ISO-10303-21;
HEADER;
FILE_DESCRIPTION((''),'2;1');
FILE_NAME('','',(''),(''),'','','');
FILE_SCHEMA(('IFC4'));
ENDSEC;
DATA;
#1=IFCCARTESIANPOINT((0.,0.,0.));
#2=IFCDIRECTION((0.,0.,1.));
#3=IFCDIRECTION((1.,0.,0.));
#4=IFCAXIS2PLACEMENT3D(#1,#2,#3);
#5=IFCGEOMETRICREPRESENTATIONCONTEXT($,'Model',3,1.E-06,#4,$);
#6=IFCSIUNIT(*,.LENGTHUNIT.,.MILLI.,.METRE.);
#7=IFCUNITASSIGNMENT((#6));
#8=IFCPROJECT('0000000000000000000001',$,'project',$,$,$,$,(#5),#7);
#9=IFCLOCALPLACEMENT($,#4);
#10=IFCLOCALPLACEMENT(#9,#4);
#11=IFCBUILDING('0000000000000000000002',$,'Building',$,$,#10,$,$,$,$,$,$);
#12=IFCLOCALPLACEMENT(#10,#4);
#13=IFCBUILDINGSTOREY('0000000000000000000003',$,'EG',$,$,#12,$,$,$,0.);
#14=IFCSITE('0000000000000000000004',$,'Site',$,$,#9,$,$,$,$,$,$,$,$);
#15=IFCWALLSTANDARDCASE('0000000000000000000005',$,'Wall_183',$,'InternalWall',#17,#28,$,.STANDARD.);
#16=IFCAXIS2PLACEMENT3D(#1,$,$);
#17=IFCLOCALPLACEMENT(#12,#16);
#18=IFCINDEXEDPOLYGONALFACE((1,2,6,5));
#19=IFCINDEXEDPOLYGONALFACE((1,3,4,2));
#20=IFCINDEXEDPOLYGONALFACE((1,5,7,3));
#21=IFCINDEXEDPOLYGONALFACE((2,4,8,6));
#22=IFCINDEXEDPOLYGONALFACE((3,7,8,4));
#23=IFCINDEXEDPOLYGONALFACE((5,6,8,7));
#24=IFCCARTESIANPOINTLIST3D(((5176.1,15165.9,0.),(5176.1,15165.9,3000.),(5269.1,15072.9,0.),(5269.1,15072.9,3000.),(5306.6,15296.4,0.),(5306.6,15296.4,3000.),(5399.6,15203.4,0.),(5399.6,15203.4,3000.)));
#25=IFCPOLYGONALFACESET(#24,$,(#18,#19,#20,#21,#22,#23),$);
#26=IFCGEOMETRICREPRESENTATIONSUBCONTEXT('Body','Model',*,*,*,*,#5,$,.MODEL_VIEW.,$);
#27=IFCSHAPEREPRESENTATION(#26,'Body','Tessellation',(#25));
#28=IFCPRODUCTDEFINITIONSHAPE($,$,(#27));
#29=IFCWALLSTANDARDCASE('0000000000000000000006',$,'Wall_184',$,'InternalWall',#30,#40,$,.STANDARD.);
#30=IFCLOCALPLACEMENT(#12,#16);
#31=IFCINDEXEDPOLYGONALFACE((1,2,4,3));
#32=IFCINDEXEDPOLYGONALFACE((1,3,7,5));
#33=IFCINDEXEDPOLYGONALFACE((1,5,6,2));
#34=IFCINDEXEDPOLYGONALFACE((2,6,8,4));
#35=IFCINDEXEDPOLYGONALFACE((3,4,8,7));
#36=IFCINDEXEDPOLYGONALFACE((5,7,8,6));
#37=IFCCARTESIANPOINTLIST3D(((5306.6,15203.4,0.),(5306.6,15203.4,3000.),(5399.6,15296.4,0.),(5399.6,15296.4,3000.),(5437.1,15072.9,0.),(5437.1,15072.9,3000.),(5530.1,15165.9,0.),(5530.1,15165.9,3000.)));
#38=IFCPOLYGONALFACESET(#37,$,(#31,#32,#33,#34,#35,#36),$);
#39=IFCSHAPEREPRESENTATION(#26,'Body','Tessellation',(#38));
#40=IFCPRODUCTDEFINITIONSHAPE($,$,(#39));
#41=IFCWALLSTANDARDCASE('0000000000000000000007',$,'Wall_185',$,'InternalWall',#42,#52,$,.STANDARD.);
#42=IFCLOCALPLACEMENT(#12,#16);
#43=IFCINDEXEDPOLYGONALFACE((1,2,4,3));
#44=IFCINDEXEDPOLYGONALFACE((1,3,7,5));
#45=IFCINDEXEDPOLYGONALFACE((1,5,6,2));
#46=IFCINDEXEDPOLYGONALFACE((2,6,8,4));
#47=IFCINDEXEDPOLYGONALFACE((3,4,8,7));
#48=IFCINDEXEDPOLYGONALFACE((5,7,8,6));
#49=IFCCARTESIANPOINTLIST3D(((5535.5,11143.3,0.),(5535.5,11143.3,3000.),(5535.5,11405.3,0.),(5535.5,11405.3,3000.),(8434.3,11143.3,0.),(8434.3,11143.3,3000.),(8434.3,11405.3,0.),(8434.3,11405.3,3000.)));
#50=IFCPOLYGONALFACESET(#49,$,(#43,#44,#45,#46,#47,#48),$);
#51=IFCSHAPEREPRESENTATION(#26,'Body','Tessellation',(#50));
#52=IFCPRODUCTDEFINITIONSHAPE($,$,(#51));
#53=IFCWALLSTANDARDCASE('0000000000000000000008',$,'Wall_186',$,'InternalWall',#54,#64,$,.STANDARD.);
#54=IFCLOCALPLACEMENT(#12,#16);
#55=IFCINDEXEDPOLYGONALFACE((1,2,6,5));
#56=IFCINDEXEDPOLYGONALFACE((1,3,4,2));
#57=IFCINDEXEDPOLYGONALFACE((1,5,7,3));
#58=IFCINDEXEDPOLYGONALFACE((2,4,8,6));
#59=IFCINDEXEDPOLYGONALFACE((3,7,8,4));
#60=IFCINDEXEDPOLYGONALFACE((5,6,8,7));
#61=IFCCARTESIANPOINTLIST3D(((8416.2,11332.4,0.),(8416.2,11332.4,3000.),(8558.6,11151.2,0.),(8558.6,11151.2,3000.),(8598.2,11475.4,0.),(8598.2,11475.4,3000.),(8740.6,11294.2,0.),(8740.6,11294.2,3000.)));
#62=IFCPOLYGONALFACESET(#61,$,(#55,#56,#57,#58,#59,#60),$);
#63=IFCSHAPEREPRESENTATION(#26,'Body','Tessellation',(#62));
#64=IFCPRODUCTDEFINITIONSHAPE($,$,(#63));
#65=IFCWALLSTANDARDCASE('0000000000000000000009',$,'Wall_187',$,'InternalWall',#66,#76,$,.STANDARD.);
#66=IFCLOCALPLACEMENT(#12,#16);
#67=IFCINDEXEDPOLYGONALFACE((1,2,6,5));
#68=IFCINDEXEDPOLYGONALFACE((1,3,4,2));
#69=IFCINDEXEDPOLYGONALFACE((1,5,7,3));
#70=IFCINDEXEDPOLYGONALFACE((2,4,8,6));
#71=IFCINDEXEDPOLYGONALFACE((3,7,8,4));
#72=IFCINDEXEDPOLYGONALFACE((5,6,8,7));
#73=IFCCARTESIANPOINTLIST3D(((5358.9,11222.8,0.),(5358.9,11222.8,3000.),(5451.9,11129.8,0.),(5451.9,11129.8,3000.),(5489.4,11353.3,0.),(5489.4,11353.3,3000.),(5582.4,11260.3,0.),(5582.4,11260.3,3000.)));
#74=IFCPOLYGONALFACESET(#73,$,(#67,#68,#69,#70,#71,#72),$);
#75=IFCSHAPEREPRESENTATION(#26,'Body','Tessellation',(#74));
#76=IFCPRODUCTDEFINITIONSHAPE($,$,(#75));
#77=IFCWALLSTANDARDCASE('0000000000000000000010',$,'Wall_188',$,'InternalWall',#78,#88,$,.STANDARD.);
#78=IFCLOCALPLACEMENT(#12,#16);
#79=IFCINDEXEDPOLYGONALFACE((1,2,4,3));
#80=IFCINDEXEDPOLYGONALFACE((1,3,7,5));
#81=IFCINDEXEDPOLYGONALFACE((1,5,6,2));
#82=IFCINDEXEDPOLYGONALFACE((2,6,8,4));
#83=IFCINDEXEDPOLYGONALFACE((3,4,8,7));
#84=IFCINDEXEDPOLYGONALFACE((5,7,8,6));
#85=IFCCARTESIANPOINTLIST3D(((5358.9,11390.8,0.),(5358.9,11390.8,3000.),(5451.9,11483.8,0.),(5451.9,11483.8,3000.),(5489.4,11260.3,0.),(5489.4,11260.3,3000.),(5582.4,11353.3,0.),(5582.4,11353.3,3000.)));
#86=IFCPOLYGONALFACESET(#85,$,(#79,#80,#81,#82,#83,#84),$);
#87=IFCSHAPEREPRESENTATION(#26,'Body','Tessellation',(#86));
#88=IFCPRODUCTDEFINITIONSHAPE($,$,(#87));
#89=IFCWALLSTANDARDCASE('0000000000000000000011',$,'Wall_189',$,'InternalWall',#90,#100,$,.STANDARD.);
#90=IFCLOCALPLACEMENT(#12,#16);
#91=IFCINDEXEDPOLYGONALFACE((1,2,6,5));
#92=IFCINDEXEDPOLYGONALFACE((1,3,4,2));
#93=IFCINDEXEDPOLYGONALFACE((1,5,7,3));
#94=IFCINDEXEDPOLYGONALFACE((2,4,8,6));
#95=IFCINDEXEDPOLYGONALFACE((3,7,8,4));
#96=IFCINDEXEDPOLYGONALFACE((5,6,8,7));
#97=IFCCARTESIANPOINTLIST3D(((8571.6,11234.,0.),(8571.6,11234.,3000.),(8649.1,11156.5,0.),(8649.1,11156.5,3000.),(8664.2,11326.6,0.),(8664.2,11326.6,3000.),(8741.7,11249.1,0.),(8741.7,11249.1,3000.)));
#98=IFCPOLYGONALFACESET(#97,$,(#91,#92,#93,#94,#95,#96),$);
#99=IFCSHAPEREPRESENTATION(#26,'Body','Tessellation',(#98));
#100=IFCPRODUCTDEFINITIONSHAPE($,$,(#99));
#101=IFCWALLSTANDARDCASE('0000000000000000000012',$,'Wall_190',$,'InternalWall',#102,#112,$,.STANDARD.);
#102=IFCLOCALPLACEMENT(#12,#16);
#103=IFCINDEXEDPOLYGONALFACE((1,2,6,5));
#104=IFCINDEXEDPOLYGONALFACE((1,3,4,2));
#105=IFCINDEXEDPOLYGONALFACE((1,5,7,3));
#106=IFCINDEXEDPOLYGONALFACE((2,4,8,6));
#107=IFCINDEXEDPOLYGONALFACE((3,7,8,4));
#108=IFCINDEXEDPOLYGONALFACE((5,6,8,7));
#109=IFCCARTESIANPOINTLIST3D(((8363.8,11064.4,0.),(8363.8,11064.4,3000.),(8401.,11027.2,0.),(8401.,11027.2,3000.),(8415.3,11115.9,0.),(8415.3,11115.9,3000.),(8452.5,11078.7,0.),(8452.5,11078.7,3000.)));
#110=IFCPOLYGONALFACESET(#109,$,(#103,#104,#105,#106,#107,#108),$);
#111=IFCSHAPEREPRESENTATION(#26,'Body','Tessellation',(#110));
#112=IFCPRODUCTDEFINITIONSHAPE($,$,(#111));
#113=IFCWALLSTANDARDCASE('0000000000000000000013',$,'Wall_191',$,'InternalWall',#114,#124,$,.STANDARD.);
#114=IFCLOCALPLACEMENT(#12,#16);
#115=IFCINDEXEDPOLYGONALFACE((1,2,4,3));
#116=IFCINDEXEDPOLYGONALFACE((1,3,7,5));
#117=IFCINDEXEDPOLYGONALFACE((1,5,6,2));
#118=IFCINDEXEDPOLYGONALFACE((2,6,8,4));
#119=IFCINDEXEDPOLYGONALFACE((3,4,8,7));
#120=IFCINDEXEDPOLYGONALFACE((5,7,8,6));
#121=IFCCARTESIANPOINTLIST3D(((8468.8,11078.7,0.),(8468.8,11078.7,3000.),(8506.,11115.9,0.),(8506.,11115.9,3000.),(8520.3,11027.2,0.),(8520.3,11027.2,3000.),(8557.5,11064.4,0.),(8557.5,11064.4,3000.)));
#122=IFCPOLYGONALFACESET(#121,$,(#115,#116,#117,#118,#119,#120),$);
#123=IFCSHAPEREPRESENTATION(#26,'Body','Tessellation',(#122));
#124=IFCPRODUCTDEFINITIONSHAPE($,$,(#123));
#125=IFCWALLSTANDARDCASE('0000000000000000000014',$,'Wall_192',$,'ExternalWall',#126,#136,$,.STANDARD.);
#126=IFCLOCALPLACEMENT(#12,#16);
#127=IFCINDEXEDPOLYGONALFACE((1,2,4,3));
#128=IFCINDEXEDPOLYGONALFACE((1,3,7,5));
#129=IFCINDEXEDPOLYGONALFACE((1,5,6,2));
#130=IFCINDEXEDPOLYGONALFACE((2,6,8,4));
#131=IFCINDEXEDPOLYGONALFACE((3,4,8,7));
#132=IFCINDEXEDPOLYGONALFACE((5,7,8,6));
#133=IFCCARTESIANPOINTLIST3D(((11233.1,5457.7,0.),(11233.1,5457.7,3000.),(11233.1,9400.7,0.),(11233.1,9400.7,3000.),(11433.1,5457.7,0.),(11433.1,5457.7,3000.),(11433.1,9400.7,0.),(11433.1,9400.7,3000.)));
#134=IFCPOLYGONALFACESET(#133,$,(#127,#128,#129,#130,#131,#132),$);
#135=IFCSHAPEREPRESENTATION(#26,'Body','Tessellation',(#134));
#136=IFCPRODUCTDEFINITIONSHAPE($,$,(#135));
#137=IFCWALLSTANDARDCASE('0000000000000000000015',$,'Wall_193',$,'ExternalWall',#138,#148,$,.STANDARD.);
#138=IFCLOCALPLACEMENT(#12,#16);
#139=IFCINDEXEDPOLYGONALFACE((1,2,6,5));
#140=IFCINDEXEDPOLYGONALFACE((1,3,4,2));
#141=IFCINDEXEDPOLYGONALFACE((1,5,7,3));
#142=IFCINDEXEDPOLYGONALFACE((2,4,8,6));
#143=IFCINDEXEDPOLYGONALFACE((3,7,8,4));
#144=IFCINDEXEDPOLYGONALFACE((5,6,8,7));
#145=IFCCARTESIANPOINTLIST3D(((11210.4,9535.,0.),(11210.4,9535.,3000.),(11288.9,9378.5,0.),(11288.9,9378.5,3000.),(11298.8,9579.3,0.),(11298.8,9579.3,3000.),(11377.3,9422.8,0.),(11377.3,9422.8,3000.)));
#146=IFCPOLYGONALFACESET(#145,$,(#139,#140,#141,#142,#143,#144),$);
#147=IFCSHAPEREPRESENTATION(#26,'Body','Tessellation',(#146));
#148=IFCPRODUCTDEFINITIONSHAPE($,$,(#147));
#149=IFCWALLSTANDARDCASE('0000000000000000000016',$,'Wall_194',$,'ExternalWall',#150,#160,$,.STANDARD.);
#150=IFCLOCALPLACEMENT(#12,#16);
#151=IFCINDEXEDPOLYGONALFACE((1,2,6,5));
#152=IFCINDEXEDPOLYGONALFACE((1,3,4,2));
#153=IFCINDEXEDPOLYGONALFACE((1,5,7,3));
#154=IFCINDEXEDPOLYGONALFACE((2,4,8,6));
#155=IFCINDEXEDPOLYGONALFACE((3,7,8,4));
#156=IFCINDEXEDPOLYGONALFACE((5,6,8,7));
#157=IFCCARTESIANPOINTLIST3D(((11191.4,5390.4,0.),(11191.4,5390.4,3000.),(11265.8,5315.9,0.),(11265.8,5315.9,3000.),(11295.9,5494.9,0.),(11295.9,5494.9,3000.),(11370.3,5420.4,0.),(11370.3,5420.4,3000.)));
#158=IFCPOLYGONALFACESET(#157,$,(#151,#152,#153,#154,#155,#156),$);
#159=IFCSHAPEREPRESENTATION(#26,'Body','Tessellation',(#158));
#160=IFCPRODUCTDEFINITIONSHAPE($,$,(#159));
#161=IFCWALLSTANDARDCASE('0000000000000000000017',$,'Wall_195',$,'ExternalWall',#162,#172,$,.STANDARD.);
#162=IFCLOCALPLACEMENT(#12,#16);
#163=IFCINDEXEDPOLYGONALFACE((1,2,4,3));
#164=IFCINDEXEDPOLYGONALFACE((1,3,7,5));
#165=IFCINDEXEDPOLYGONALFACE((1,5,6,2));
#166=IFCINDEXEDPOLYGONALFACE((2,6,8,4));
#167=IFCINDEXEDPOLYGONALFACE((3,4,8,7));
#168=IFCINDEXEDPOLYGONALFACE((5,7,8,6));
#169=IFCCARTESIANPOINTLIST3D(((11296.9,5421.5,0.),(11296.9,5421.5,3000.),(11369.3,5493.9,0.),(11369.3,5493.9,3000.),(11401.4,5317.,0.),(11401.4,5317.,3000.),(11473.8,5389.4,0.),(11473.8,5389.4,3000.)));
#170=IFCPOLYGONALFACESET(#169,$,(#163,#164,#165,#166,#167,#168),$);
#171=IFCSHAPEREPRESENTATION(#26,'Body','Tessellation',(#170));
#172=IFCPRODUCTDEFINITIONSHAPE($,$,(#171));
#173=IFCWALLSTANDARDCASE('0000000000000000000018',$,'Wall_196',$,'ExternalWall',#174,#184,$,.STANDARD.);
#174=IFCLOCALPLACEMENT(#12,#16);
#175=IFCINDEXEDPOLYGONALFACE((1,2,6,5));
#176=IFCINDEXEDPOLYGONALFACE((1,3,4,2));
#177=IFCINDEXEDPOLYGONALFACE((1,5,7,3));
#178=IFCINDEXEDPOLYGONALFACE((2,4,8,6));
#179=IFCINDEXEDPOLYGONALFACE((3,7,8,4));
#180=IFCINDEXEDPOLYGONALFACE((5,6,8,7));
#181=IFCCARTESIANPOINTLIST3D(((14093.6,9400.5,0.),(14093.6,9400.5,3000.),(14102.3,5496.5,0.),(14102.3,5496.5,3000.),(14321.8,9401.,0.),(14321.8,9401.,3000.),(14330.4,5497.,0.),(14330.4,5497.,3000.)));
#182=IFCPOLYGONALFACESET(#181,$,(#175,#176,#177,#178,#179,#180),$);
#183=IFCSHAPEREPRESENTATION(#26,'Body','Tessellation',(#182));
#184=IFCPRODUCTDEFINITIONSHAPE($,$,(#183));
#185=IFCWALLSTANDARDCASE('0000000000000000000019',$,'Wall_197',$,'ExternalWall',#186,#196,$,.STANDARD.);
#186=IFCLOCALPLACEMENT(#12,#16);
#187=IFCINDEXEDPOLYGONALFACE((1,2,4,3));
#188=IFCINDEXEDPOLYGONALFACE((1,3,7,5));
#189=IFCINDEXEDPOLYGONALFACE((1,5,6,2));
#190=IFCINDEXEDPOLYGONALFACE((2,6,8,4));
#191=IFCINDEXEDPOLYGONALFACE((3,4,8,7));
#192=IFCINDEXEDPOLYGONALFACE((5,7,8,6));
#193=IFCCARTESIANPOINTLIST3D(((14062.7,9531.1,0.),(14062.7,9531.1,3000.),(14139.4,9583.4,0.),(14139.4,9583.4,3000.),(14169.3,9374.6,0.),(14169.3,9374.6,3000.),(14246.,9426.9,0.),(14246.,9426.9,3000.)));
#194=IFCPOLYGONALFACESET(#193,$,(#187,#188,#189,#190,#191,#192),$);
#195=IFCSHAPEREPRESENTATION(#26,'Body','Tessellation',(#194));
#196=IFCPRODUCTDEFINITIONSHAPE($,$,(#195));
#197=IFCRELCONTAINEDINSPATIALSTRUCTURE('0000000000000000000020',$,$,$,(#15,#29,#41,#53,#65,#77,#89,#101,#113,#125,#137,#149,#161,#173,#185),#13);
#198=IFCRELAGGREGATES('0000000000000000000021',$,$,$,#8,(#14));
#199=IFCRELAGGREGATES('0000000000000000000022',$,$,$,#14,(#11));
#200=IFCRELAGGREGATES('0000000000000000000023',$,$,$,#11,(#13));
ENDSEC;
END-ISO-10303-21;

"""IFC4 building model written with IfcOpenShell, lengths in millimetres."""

from ifc_helpers import new_model, si_unit, frame, origin_with_axes, place, context, subcontext, project, spatial, rectangle, extrude, element, save


model = new_model("IFC4")

# Units and contexts
model_context = context("Model", 3, precision=1e-06, world=origin_with_axes())
body_context = subcontext(model_context, "Body", "Model", "MODEL_VIEW")
ifc_project = project(units=[si_unit("LENGTHUNIT", "METRE", prefix="MILLI")], contexts=[model_context])

# Site, building, storey
site_placement = place(None, origin_with_axes())
site = spatial("IfcSite", under=ifc_project, at=site_placement, Name="Site")
building_placement = place(site_placement, origin_with_axes())
building = spatial("IfcBuilding", under=site, at=building_placement, Name="Building")
storey_placement = place(building_placement, origin_with_axes())
storey = spatial("IfcBuildingStorey", under=building, at=storey_placement, Name="EG", Elevation=0.0)

# Walls
wall_1_placement = place(storey_placement, origin_with_axes())
element("IfcWallStandardCase", 1, at=wall_1_placement, inside=storey, Name="Wall_183", ObjectType="InternalWall", PredefinedType="STANDARD", context=body_context, shape_type="SweptSolid", body=[
    extrude(rectangle(XDim=184.6, YDim=131.5), frame((5287.9, 15184.7, 0.0), z_axis=(0.0, 0.0, 1.0), x_axis=(-0.707107, -0.707107, 0.0)), (0.0, 0.0, 1.0), 3000.0),
])
wall_2_placement = place(storey_placement, origin_with_axes())
element("IfcWallStandardCase", 2, at=wall_2_placement, inside=storey, Name="Wall_184", ObjectType="InternalWall", PredefinedType="STANDARD", context=body_context, shape_type="SweptSolid", body=[
    extrude(rectangle(XDim=184.6, YDim=131.5), frame((5418.4, 15184.7, 0.0), z_axis=(0.0, 0.0, 1.0), x_axis=(0.707107, -0.707107, 0.0)), (0.0, 0.0, 1.0), 3000.0),
])
wall_3_placement = place(storey_placement, origin_with_axes())
element("IfcWallStandardCase", 3, at=wall_3_placement, inside=storey, Name="Wall_185", ObjectType="InternalWall", PredefinedType="STANDARD", context=body_context, shape_type="SweptSolid", body=[
    extrude(rectangle(XDim=2898.7, YDim=262.0), frame((6984.9, 11274.3, 0.0), z_axis=(0.0, 0.0, 1.0), x_axis=(-1.0, 0.0, 0.0)), (0.0, 0.0, 1.0), 3000.0),
])
wall_4_placement = place(storey_placement, origin_with_axes())
element("IfcWallStandardCase", 4, at=wall_4_placement, inside=storey, Name="Wall_186", ObjectType="InternalWall", PredefinedType="STANDARD", context=body_context, shape_type="SweptSolid", body=[
    extrude(rectangle(XDim=231.5, YDim=230.5), frame((8578.4, 11313.3, 0.0), z_axis=(0.0, 0.0, 1.0), x_axis=(0.786318, 0.617822, 0.0)), (0.0, 0.0, 1.0), 3000.0),
])
wall_5_placement = place(storey_placement, origin_with_axes())
element("IfcWallStandardCase", 5, at=wall_5_placement, inside=storey, Name="Wall_187", ObjectType="InternalWall", PredefinedType="STANDARD", context=body_context, shape_type="SweptSolid", body=[
    extrude(rectangle(XDim=184.6, YDim=131.5), frame((5470.6, 11241.6, 0.0), z_axis=(0.0, 0.0, 1.0), x_axis=(-0.707107, -0.707107, 0.0)), (0.0, 0.0, 1.0), 3000.0),
])
wall_6_placement = place(storey_placement, origin_with_axes())
element("IfcWallStandardCase", 6, at=wall_6_placement, inside=storey, Name="Wall_188", ObjectType="InternalWall", PredefinedType="STANDARD", context=body_context, shape_type="SweptSolid", body=[
    extrude(rectangle(XDim=184.6, YDim=131.5), frame((5470.6, 11372.1, 0.0), z_axis=(0.0, 0.0, 1.0), x_axis=(-0.707107, 0.707107, 0.0)), (0.0, 0.0, 1.0), 3000.0),
])
wall_7_placement = place(storey_placement, origin_with_axes())
element("IfcWallStandardCase", 7, at=wall_7_placement, inside=storey, Name="Wall_189", ObjectType="InternalWall", PredefinedType="STANDARD", context=body_context, shape_type="SweptSolid", body=[
    extrude(rectangle(XDim=109.6, YDim=131.0), frame((8656.6, 11241.6, 0.0), z_axis=(0.0, 0.0, 1.0), x_axis=(0.707107, -0.707107, 0.0)), (0.0, 0.0, 1.0), 3000.0),
])
wall_8_placement = place(storey_placement, origin_with_axes())
element("IfcWallStandardCase", 8, at=wall_8_placement, inside=storey, Name="Wall_190", ObjectType="InternalWall", PredefinedType="STANDARD", context=body_context, shape_type="SweptSolid", body=[
    extrude(rectangle(XDim=72.8, YDim=52.5), frame((8408.1, 11071.6, 0.0), z_axis=(0.0, 0.0, 1.0), x_axis=(-0.707107, -0.707107, 0.0)), (0.0, 0.0, 1.0), 3000.0),
])
wall_9_placement = place(storey_placement, origin_with_axes())
element("IfcWallStandardCase", 9, at=wall_9_placement, inside=storey, Name="Wall_191", ObjectType="InternalWall", PredefinedType="STANDARD", context=body_context, shape_type="SweptSolid", body=[
    extrude(rectangle(XDim=72.8, YDim=52.5), frame((8513.1, 11071.6, 0.0), z_axis=(0.0, 0.0, 1.0), x_axis=(0.707107, -0.707107, 0.0)), (0.0, 0.0, 1.0), 3000.0),
])
wall_10_placement = place(storey_placement, origin_with_axes())
element("IfcWallStandardCase", 10, at=wall_10_placement, inside=storey, Name="Wall_192", ObjectType="ExternalWall", PredefinedType="STANDARD", context=body_context, shape_type="SweptSolid", body=[
    extrude(rectangle(XDim=3943.0, YDim=200.0), frame((11333.1, 7429.2, 0.0), z_axis=(0.0, 0.0, 1.0), x_axis=(0.0, -1.0, 0.0)), (0.0, 0.0, 1.0), 3000.0),
])
wall_11_placement = place(storey_placement, origin_with_axes())
element("IfcWallStandardCase", 11, at=wall_11_placement, inside=storey, Name="Wall_193", ObjectType="ExternalWall", PredefinedType="STANDARD", context=body_context, shape_type="SweptSolid", body=[
    extrude(rectangle(XDim=175.1, YDim=98.8), frame((11293.8, 9478.9, 0.0), z_axis=(0.0, 0.0, 1.0), x_axis=(-0.448356, 0.893855, 0.0)), (0.0, 0.0, 1.0), 3000.0),
])
wall_12_placement = place(storey_placement, origin_with_axes())
element("IfcWallStandardCase", 12, at=wall_12_placement, inside=storey, Name="Wall_194", ObjectType="ExternalWall", PredefinedType="STANDARD", context=body_context, shape_type="SweptSolid", body=[
    extrude(rectangle(XDim=147.8, YDim=105.3), frame((11280.8, 5405.4, 0.0), z_axis=(0.0, 0.0, 1.0), x_axis=(-0.707107, -0.707107, 0.0)), (0.0, 0.0, 1.0), 3000.0),
])
wall_13_placement = place(storey_placement, origin_with_axes())
element("IfcWallStandardCase", 13, at=wall_13_placement, inside=storey, Name="Wall_195", ObjectType="ExternalWall", PredefinedType="STANDARD", context=body_context, shape_type="SweptSolid", body=[
    extrude(rectangle(XDim=147.8, YDim=102.4), frame((11385.3, 5405.4, 0.0), z_axis=(0.0, 0.0, 1.0), x_axis=(0.707107, -0.707107, 0.0)), (0.0, 0.0, 1.0), 3000.0),
])
wall_14_placement = place(storey_placement, origin_with_axes())
element("IfcWallStandardCase", 14, at=wall_14_placement, inside=storey, Name="Wall_196", ObjectType="ExternalWall", PredefinedType="STANDARD", context=body_context, shape_type="SweptSolid", body=[
    extrude(rectangle(XDim=3904.0, YDim=228.2), frame((14212.0, 7448.8, 0.0), z_axis=(0.0, 0.0, 1.0), x_axis=(0.00222, -0.999998, 0.0)), (0.0, 0.0, 1.0), 3000.0),
])
wall_15_placement = place(storey_placement, origin_with_axes())
element("IfcWallStandardCase", 15, at=wall_15_placement, inside=storey, Name="Wall_197", ObjectType="ExternalWall", PredefinedType="STANDARD", context=body_context, shape_type="SweptSolid", body=[
    extrude(rectangle(XDim=189.4, YDim=92.8), frame((14154.4, 9479.0, 0.0), z_axis=(0.0, 0.0, 1.0), x_axis=(-0.563209, 0.826314, 0.0)), (0.0, 0.0, 1.0), 3000.0),
])

save(model, "model.ifc")
